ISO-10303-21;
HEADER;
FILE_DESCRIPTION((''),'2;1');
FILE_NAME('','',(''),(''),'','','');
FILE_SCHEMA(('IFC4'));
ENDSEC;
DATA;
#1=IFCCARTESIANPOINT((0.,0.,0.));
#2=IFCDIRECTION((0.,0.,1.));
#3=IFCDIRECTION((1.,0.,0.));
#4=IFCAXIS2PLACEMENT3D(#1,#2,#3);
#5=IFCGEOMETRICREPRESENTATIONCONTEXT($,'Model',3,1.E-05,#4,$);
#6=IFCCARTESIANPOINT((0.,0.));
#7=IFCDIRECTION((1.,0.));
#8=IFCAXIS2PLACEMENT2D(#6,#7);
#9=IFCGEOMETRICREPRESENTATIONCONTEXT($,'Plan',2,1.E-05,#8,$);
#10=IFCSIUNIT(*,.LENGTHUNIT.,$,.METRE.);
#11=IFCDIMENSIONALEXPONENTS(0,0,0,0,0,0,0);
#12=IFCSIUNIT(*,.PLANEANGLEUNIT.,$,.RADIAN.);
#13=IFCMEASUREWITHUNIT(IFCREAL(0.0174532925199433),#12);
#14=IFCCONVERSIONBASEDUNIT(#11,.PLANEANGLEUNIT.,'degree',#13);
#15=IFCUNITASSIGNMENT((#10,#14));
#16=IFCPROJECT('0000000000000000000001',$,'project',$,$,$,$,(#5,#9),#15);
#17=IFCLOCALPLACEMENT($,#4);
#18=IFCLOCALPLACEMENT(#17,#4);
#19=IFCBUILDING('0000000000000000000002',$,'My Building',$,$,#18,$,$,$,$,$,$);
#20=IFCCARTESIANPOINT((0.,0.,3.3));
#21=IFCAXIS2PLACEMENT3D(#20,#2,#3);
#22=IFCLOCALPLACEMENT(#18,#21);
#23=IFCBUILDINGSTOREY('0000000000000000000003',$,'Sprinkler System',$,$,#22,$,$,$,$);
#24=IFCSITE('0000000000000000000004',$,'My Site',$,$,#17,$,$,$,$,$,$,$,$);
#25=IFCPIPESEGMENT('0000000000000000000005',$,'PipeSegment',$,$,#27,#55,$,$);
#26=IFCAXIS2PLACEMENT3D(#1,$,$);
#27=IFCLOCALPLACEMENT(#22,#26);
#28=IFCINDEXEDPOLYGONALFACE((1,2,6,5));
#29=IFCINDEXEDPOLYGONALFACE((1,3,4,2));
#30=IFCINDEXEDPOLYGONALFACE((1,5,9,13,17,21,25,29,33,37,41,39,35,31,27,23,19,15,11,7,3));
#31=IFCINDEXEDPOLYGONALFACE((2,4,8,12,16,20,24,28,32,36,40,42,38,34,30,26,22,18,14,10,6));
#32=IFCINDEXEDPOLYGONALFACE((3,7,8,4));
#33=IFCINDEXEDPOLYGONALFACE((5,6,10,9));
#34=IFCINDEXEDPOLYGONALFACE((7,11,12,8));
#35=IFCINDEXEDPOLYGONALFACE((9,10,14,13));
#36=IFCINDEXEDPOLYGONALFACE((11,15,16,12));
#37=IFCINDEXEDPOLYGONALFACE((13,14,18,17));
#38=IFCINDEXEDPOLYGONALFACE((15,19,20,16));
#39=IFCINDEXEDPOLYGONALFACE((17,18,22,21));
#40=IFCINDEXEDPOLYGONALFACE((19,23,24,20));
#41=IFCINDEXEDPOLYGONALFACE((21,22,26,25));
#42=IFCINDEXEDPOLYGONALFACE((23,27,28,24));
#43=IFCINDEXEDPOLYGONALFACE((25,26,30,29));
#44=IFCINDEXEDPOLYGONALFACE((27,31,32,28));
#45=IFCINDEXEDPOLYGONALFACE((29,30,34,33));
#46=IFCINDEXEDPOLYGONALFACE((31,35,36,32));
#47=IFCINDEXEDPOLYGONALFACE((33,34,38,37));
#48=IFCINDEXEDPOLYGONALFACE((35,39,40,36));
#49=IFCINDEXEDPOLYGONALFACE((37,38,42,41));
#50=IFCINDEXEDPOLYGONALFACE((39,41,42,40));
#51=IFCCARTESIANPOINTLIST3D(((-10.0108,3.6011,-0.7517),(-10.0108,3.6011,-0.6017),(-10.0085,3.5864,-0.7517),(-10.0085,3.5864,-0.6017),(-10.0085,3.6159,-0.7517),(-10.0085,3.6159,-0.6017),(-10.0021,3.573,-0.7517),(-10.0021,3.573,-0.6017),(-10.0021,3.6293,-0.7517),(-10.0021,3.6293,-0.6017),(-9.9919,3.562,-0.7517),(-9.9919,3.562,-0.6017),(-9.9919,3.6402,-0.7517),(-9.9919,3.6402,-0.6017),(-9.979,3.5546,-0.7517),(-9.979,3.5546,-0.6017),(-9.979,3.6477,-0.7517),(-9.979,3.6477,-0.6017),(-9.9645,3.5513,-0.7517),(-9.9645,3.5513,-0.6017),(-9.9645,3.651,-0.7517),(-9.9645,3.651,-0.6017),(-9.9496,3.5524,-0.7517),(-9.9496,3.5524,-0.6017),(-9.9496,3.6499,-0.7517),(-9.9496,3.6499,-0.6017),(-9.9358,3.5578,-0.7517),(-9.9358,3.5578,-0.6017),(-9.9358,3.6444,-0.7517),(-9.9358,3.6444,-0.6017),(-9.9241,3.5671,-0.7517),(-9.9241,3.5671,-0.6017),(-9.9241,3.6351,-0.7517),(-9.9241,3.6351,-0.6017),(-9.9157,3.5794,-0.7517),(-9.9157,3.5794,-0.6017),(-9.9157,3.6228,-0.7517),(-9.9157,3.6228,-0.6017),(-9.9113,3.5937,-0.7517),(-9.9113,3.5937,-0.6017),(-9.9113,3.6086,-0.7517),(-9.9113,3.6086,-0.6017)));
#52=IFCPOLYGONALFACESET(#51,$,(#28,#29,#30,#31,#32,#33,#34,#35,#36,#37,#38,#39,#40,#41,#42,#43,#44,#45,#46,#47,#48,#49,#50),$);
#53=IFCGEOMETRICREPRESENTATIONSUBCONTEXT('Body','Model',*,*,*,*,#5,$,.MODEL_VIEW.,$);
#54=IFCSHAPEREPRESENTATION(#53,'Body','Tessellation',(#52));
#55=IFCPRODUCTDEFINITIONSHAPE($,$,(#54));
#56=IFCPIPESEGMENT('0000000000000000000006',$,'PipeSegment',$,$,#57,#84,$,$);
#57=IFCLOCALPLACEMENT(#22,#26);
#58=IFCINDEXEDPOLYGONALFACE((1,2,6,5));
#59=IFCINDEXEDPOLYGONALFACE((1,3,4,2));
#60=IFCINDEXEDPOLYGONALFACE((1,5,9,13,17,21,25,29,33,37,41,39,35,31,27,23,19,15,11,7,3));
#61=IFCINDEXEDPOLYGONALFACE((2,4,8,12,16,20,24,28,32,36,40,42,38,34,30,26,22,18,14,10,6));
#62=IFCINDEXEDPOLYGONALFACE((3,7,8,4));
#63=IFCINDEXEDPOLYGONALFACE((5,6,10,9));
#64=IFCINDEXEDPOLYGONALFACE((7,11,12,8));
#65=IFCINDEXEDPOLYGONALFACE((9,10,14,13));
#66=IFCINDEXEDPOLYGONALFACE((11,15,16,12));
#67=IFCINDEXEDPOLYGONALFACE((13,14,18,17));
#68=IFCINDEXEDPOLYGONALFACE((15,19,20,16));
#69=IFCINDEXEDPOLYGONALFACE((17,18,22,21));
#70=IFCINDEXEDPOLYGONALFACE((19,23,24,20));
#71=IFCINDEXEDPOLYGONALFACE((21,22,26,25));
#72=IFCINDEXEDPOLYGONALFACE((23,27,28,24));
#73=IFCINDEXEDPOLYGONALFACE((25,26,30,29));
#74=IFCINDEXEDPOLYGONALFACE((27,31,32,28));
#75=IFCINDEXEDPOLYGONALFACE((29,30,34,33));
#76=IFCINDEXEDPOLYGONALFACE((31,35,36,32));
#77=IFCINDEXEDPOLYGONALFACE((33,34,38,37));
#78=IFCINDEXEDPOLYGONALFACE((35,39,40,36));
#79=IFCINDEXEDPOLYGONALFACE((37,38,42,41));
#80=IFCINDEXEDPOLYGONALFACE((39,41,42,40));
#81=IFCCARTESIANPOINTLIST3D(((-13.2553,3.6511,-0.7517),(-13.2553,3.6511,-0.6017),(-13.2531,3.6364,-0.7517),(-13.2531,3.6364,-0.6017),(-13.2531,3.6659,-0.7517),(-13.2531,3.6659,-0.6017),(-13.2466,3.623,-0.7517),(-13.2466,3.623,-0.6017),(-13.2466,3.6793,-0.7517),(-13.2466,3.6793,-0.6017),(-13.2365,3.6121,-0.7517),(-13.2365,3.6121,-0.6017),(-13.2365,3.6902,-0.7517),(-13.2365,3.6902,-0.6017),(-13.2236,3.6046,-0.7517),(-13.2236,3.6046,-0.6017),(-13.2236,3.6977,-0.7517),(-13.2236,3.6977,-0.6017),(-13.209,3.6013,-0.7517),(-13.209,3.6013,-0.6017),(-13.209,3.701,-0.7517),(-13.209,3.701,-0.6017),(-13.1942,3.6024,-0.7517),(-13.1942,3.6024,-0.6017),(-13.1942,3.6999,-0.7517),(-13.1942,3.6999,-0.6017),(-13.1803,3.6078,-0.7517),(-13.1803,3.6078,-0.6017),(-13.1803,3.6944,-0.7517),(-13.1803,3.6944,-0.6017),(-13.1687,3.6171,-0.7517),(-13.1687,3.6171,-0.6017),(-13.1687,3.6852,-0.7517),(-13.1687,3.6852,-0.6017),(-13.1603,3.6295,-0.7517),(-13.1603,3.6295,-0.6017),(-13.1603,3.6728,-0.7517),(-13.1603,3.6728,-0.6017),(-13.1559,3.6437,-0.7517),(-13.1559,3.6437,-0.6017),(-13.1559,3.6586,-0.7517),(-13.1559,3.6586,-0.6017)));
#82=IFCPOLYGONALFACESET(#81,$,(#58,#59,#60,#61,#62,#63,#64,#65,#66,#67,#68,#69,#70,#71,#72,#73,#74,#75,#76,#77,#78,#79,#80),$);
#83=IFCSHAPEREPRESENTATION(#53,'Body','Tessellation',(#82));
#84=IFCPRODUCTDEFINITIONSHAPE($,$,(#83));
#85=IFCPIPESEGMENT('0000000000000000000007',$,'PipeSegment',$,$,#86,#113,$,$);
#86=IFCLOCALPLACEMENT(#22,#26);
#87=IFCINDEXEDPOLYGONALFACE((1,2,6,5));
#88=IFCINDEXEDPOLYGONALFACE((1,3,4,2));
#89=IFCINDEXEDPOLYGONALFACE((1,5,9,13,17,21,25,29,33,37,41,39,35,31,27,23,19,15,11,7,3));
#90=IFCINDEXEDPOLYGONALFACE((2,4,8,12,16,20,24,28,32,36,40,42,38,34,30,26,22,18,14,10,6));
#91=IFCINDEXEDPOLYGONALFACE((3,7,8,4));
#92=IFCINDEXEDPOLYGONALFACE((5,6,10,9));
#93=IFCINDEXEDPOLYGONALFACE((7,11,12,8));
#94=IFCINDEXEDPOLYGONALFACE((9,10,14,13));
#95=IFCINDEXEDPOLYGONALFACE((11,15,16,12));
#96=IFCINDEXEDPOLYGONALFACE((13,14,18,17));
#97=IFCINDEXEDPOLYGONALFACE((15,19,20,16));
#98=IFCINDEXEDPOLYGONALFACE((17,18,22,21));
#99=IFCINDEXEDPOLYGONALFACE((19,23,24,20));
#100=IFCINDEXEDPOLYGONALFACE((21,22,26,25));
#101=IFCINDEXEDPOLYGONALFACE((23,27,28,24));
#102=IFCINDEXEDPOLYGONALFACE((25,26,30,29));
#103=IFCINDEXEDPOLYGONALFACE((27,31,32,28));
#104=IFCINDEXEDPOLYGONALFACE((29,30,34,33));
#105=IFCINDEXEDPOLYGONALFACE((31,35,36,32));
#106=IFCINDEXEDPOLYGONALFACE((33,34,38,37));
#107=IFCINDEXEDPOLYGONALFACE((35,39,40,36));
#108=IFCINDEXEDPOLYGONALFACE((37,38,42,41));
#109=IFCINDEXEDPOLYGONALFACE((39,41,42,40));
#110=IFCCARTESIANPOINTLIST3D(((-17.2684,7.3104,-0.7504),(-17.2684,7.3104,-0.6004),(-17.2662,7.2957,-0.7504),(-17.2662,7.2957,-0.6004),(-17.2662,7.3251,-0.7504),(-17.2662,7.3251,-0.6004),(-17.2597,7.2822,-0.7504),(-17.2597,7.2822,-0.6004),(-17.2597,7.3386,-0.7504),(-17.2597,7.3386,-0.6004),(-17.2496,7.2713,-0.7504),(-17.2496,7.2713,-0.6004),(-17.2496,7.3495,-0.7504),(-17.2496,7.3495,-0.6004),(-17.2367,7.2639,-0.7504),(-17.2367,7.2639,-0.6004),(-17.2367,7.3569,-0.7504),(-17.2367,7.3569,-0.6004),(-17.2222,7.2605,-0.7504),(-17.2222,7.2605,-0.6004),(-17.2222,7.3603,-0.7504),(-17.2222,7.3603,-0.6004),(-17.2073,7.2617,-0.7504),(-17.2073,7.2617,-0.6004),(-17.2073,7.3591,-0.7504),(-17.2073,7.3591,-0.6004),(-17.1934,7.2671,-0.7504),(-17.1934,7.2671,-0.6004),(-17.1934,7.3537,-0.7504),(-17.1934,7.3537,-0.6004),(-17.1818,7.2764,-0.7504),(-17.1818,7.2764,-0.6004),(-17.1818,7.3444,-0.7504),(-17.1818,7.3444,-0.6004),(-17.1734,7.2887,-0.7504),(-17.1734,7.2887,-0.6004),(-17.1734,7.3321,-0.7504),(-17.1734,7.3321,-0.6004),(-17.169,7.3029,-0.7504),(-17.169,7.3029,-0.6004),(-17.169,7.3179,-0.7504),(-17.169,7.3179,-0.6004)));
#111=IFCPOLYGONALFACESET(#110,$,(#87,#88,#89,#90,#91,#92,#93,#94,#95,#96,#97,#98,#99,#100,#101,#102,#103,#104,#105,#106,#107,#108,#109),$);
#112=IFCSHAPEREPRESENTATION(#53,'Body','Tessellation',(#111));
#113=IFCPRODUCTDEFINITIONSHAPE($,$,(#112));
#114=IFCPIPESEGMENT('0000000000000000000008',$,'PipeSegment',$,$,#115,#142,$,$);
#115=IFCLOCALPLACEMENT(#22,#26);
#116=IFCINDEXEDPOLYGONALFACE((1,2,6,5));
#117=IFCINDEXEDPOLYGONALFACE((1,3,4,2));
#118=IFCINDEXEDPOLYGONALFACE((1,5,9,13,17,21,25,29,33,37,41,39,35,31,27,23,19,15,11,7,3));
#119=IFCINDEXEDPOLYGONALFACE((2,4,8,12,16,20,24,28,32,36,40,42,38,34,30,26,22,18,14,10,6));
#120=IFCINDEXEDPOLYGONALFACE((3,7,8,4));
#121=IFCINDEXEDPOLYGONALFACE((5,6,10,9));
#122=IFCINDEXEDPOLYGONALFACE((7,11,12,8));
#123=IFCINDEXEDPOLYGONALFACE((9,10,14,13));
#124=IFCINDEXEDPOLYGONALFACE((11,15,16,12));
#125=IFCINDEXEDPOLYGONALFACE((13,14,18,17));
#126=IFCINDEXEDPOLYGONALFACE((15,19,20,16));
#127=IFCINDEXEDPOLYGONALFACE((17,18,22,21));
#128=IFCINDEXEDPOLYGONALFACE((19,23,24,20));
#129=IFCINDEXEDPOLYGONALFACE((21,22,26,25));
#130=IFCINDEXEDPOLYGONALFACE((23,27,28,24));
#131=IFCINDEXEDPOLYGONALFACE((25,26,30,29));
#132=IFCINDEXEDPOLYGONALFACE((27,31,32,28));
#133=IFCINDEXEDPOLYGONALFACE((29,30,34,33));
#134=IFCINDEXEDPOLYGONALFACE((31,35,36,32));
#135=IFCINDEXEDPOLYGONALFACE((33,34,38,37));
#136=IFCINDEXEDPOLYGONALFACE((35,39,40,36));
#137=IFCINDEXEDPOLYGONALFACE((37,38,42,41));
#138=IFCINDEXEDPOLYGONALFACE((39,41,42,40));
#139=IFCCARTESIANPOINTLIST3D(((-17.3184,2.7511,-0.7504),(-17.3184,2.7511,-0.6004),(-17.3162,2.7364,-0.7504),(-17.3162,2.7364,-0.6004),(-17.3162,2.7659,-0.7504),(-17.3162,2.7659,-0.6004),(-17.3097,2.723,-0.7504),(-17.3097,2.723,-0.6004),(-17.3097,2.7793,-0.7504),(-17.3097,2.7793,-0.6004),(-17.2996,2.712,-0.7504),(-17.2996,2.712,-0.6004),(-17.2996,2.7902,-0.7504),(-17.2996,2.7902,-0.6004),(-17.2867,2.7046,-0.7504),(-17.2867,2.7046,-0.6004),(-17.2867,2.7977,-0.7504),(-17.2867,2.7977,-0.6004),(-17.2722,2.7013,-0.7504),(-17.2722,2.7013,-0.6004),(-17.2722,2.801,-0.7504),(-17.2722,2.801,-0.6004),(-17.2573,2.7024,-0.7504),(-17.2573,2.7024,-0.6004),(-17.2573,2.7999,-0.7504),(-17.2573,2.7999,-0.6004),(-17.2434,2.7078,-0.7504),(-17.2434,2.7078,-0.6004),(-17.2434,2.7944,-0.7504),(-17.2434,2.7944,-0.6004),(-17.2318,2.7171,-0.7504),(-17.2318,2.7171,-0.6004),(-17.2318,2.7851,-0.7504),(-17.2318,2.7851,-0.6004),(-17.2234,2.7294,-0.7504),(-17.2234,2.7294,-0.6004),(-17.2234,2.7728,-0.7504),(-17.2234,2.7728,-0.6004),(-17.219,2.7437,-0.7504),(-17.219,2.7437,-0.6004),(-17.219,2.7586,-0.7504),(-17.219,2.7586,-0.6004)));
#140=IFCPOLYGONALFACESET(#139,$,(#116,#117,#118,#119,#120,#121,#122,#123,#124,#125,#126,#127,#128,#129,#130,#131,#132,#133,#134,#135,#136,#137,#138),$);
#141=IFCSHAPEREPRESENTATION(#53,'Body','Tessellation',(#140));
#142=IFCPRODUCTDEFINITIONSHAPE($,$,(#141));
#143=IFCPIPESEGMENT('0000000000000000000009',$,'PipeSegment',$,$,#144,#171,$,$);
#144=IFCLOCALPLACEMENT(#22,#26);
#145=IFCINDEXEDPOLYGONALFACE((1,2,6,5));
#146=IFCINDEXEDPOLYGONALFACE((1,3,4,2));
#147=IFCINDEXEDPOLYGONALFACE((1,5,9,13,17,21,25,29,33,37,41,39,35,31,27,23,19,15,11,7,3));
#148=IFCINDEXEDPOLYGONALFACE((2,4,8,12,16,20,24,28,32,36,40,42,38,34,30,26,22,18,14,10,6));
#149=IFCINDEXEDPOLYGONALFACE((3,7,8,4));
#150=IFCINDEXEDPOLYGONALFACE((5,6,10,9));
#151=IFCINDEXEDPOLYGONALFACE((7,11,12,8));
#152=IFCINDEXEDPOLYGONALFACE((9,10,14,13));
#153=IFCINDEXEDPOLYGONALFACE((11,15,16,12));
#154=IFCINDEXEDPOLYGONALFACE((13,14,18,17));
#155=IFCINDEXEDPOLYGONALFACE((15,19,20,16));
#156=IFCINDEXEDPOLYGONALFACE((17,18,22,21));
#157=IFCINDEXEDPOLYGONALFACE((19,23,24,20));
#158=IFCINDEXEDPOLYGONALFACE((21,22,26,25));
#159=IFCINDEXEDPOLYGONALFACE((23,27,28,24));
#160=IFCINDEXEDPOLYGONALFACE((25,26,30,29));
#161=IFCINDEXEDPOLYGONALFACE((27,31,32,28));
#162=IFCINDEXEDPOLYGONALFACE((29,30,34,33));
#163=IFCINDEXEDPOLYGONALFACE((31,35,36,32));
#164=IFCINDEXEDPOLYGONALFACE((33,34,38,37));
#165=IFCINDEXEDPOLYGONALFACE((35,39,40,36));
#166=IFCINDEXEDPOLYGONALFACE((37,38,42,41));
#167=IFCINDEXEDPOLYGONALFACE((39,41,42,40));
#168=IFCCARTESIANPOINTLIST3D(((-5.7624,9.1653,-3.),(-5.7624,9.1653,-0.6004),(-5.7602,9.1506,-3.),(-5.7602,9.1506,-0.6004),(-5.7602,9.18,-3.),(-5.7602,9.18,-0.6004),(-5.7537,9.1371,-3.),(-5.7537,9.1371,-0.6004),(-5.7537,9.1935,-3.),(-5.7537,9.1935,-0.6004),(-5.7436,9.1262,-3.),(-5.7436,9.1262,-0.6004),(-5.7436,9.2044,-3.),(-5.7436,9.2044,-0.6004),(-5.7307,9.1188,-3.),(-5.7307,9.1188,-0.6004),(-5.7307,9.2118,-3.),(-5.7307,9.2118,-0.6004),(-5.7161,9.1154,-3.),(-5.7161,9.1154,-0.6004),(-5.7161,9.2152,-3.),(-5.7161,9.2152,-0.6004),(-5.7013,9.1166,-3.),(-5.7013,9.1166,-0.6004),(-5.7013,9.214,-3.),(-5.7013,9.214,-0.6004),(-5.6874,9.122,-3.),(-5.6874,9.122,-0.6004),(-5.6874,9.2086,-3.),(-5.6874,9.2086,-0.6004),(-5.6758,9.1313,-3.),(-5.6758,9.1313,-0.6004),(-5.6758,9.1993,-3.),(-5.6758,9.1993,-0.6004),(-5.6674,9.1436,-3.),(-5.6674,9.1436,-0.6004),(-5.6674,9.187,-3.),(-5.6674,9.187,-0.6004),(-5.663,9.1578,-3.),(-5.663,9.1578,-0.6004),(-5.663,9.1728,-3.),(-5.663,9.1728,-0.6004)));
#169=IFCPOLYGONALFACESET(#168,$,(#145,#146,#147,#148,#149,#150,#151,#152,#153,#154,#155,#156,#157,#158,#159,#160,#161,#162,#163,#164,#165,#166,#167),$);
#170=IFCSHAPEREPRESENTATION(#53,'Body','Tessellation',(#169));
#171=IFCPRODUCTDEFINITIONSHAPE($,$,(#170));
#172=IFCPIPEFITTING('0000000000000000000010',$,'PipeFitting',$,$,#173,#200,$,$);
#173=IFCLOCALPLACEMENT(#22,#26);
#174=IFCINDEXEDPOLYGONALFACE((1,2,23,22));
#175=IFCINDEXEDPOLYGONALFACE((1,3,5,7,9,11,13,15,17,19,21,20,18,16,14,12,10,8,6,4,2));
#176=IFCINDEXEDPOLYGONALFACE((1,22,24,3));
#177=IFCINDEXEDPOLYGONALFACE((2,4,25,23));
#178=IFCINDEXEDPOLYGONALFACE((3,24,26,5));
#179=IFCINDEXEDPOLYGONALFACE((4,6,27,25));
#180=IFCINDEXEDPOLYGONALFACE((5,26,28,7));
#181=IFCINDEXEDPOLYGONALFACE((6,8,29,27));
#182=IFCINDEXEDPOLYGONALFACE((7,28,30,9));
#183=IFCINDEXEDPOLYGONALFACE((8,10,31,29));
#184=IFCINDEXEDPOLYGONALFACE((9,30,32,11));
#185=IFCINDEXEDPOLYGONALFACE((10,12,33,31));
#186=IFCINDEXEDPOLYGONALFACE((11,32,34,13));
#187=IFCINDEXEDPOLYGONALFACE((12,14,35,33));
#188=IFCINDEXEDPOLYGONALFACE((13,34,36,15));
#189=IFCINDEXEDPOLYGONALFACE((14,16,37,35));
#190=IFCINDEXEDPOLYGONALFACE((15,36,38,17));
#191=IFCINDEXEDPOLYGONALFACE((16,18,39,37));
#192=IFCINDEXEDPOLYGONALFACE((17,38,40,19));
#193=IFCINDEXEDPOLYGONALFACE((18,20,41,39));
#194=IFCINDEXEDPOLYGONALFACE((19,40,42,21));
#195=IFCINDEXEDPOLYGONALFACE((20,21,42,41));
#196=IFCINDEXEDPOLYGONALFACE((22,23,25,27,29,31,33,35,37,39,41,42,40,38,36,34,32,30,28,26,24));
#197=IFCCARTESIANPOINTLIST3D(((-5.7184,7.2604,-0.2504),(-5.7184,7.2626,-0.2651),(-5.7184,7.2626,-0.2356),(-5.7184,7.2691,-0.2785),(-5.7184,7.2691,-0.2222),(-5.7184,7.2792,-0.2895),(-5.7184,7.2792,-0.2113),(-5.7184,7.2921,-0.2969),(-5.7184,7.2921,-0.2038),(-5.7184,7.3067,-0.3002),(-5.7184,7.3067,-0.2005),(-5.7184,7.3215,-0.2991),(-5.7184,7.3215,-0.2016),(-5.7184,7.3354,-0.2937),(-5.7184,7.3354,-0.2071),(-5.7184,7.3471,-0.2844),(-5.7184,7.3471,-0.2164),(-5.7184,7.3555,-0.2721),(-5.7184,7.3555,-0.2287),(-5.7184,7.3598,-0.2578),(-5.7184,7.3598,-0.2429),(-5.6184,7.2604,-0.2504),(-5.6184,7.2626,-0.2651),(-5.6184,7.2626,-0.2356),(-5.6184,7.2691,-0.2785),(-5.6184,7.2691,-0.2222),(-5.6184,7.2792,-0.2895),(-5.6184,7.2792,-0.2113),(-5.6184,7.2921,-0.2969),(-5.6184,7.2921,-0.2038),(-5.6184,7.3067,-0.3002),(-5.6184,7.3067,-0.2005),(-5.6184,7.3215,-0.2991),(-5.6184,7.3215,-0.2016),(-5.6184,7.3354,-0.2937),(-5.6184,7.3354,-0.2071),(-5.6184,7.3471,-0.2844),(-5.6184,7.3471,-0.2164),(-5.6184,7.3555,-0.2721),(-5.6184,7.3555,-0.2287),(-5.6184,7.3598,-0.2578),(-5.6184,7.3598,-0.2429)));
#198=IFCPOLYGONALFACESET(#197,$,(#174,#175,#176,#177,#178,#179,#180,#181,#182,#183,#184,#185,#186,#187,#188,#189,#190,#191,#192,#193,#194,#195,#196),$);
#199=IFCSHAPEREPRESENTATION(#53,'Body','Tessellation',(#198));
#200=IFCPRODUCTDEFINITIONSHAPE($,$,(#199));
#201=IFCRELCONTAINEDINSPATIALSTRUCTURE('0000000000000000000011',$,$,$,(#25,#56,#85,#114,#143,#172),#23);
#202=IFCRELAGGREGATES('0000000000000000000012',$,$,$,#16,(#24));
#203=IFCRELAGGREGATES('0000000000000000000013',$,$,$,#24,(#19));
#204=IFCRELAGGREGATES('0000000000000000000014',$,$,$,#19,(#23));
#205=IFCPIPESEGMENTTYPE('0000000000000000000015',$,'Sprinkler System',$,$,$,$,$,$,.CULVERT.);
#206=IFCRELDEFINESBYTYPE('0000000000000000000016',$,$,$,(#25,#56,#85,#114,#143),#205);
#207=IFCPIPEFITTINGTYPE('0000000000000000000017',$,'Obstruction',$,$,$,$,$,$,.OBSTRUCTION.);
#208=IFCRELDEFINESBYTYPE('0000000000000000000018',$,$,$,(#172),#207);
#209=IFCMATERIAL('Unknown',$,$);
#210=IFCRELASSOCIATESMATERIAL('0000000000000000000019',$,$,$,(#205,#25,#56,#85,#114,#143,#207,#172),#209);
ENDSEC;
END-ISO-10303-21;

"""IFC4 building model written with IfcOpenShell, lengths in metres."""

from ifc_helpers import new_model, entity, si_unit, converted_unit, frame, origin_with_axes, origin_2d_with_axis, place, context, subcontext, project, spatial, circle, extrude, material, material_profile, profile_set, profile_usage, type_object, element, save


model = new_model("IFC4")

# Units and contexts
model_context = context("Model", 3, precision=1e-05, world=origin_with_axes())
plan_context = context("Plan", 2, precision=1e-05, world=origin_2d_with_axis())
body_context = subcontext(model_context, "Body", "Model", "MODEL_VIEW")
ifc_project = project(units=[si_unit("LENGTHUNIT", "METRE"), converted_unit("PLANEANGLEUNIT", "degree", entity("IfcReal", 0.0174532925199433), si_unit("PLANEANGLEUNIT", "RADIAN"), dimensions=[0, 0, 0, 0, 0, 0, 0])], contexts=[model_context, plan_context])

# Site, building, storey
site_placement = place(None, origin_with_axes())
site = spatial("IfcSite", under=ifc_project, at=site_placement, Name="My Site")
building_placement = place(site_placement, origin_with_axes())
building = spatial("IfcBuilding", under=site, at=building_placement, Name="My Building")
storey_placement = place(building_placement, frame((0.0, 0.0, 3.3), z_axis=(0.0, 0.0, 1.0), x_axis=(1.0, 0.0, 0.0)))
storey = spatial("IfcBuildingStorey", under=building, at=storey_placement, Name="Sprinkler System")

# Pipe segments
ifc_material = material(Name="Unknown")
ifc_material_profile_1 = material_profile(ifc_material, circle(Radius=0.05))
ifc_profile_set_1 = profile_set([ifc_material_profile_1])
pipe_segment_type = type_object("IfcPipeSegmentType", Name="Sprinkler System", PredefinedType="CULVERT", material=ifc_profile_set_1)
ifc_profile_usage_1 = profile_usage(ifc_profile_set_1, cardinal=5)
pipe_segment_1_placement = place(storey_placement, frame((-9.9608, 3.6011, -0.6017), z_axis=(0.0, 0.0, -1.0), x_axis=(-1.0, 0.0, 0.0)))
element("IfcPipeSegment", 1, at=pipe_segment_1_placement, inside=storey, type_object=pipe_segment_type, material=ifc_profile_usage_1, Name="PipeSegment", context=body_context, shape_type="SweptSolid", body=[
    extrude(circle(Radius=0.05), origin_with_axes(), (0.0, 0.0, 1.0), 0.15),
])
ifc_profile_usage_2 = profile_usage(ifc_profile_set_1, cardinal=5)
pipe_segment_2_placement = place(storey_placement, frame((-13.2053, 3.6511, -0.6017), z_axis=(0.0, 0.0, -1.0), x_axis=(-1.0, 0.0, 0.0)))
element("IfcPipeSegment", 2, at=pipe_segment_2_placement, inside=storey, type_object=pipe_segment_type, material=ifc_profile_usage_2, Name="PipeSegment", context=body_context, shape_type="SweptSolid", body=[
    extrude(circle(Radius=0.05), origin_with_axes(), (0.0, 0.0, 1.0), 0.15),
])
ifc_profile_usage_3 = profile_usage(ifc_profile_set_1, cardinal=5)
pipe_segment_3_placement = place(storey_placement, frame((-17.2184, 7.3104, -0.6004), z_axis=(0.0, 0.0, -1.0), x_axis=(-1.0, 0.0, 0.0)))
element("IfcPipeSegment", 3, at=pipe_segment_3_placement, inside=storey, type_object=pipe_segment_type, material=ifc_profile_usage_3, Name="PipeSegment", context=body_context, shape_type="SweptSolid", body=[
    extrude(circle(Radius=0.05), origin_with_axes(), (0.0, 0.0, 1.0), 0.15),
])
ifc_profile_usage_4 = profile_usage(ifc_profile_set_1, cardinal=5)
pipe_segment_4_placement = place(storey_placement, frame((-17.2684, 2.7511, -0.6004), z_axis=(0.0, 0.0, -1.0), x_axis=(-1.0, 0.0, 0.0)))
element("IfcPipeSegment", 4, at=pipe_segment_4_placement, inside=storey, type_object=pipe_segment_type, material=ifc_profile_usage_4, Name="PipeSegment", context=body_context, shape_type="SweptSolid", body=[
    extrude(circle(Radius=0.05), origin_with_axes(), (0.0, 0.0, 1.0), 0.15),
])
ifc_profile_usage_5 = profile_usage(ifc_profile_set_1, cardinal=5)
pipe_segment_5_placement = place(storey_placement, frame((-5.7124, 9.1653, -0.6004), z_axis=(0.0, 0.0, -1.0), x_axis=(-1.0, 0.0, 0.0)))
element("IfcPipeSegment", 5, at=pipe_segment_5_placement, inside=storey, type_object=pipe_segment_type, material=ifc_profile_usage_5, Name="PipeSegment", context=body_context, shape_type="SweptSolid", body=[
    extrude(circle(Radius=0.05), origin_with_axes(), (0.0, 0.0, 1.0), 2.3996),
])

# Pipe fitting
ifc_material_profile_2 = material_profile(ifc_material, circle(Radius=0.05))
ifc_profile_set_2 = profile_set([ifc_material_profile_2])
ifc_profile_usage_6 = profile_usage(ifc_profile_set_2, cardinal=5)
pipe_fitting_type_1 = type_object("IfcPipeFittingType", Name="Obstruction", PredefinedType="OBSTRUCTION", material=ifc_profile_set_2)
pipe_fitting_1_placement = place(storey_placement, frame((-5.6184, 7.3104, -0.2504), z_axis=(-1.0, 0.0, 0.0), x_axis=(0.0, -1.0, 0.0)))
element("IfcPipeFitting", 6, at=pipe_fitting_1_placement, inside=storey, type_object=pipe_fitting_type_1, material=ifc_profile_usage_6, Name="PipeFitting", context=body_context, shape_type="SweptSolid", body=[
    extrude(circle(Radius=0.05), origin_with_axes(), (0.0, 0.0, 1.0), 0.1),
])

save(model, "model.ifc")
